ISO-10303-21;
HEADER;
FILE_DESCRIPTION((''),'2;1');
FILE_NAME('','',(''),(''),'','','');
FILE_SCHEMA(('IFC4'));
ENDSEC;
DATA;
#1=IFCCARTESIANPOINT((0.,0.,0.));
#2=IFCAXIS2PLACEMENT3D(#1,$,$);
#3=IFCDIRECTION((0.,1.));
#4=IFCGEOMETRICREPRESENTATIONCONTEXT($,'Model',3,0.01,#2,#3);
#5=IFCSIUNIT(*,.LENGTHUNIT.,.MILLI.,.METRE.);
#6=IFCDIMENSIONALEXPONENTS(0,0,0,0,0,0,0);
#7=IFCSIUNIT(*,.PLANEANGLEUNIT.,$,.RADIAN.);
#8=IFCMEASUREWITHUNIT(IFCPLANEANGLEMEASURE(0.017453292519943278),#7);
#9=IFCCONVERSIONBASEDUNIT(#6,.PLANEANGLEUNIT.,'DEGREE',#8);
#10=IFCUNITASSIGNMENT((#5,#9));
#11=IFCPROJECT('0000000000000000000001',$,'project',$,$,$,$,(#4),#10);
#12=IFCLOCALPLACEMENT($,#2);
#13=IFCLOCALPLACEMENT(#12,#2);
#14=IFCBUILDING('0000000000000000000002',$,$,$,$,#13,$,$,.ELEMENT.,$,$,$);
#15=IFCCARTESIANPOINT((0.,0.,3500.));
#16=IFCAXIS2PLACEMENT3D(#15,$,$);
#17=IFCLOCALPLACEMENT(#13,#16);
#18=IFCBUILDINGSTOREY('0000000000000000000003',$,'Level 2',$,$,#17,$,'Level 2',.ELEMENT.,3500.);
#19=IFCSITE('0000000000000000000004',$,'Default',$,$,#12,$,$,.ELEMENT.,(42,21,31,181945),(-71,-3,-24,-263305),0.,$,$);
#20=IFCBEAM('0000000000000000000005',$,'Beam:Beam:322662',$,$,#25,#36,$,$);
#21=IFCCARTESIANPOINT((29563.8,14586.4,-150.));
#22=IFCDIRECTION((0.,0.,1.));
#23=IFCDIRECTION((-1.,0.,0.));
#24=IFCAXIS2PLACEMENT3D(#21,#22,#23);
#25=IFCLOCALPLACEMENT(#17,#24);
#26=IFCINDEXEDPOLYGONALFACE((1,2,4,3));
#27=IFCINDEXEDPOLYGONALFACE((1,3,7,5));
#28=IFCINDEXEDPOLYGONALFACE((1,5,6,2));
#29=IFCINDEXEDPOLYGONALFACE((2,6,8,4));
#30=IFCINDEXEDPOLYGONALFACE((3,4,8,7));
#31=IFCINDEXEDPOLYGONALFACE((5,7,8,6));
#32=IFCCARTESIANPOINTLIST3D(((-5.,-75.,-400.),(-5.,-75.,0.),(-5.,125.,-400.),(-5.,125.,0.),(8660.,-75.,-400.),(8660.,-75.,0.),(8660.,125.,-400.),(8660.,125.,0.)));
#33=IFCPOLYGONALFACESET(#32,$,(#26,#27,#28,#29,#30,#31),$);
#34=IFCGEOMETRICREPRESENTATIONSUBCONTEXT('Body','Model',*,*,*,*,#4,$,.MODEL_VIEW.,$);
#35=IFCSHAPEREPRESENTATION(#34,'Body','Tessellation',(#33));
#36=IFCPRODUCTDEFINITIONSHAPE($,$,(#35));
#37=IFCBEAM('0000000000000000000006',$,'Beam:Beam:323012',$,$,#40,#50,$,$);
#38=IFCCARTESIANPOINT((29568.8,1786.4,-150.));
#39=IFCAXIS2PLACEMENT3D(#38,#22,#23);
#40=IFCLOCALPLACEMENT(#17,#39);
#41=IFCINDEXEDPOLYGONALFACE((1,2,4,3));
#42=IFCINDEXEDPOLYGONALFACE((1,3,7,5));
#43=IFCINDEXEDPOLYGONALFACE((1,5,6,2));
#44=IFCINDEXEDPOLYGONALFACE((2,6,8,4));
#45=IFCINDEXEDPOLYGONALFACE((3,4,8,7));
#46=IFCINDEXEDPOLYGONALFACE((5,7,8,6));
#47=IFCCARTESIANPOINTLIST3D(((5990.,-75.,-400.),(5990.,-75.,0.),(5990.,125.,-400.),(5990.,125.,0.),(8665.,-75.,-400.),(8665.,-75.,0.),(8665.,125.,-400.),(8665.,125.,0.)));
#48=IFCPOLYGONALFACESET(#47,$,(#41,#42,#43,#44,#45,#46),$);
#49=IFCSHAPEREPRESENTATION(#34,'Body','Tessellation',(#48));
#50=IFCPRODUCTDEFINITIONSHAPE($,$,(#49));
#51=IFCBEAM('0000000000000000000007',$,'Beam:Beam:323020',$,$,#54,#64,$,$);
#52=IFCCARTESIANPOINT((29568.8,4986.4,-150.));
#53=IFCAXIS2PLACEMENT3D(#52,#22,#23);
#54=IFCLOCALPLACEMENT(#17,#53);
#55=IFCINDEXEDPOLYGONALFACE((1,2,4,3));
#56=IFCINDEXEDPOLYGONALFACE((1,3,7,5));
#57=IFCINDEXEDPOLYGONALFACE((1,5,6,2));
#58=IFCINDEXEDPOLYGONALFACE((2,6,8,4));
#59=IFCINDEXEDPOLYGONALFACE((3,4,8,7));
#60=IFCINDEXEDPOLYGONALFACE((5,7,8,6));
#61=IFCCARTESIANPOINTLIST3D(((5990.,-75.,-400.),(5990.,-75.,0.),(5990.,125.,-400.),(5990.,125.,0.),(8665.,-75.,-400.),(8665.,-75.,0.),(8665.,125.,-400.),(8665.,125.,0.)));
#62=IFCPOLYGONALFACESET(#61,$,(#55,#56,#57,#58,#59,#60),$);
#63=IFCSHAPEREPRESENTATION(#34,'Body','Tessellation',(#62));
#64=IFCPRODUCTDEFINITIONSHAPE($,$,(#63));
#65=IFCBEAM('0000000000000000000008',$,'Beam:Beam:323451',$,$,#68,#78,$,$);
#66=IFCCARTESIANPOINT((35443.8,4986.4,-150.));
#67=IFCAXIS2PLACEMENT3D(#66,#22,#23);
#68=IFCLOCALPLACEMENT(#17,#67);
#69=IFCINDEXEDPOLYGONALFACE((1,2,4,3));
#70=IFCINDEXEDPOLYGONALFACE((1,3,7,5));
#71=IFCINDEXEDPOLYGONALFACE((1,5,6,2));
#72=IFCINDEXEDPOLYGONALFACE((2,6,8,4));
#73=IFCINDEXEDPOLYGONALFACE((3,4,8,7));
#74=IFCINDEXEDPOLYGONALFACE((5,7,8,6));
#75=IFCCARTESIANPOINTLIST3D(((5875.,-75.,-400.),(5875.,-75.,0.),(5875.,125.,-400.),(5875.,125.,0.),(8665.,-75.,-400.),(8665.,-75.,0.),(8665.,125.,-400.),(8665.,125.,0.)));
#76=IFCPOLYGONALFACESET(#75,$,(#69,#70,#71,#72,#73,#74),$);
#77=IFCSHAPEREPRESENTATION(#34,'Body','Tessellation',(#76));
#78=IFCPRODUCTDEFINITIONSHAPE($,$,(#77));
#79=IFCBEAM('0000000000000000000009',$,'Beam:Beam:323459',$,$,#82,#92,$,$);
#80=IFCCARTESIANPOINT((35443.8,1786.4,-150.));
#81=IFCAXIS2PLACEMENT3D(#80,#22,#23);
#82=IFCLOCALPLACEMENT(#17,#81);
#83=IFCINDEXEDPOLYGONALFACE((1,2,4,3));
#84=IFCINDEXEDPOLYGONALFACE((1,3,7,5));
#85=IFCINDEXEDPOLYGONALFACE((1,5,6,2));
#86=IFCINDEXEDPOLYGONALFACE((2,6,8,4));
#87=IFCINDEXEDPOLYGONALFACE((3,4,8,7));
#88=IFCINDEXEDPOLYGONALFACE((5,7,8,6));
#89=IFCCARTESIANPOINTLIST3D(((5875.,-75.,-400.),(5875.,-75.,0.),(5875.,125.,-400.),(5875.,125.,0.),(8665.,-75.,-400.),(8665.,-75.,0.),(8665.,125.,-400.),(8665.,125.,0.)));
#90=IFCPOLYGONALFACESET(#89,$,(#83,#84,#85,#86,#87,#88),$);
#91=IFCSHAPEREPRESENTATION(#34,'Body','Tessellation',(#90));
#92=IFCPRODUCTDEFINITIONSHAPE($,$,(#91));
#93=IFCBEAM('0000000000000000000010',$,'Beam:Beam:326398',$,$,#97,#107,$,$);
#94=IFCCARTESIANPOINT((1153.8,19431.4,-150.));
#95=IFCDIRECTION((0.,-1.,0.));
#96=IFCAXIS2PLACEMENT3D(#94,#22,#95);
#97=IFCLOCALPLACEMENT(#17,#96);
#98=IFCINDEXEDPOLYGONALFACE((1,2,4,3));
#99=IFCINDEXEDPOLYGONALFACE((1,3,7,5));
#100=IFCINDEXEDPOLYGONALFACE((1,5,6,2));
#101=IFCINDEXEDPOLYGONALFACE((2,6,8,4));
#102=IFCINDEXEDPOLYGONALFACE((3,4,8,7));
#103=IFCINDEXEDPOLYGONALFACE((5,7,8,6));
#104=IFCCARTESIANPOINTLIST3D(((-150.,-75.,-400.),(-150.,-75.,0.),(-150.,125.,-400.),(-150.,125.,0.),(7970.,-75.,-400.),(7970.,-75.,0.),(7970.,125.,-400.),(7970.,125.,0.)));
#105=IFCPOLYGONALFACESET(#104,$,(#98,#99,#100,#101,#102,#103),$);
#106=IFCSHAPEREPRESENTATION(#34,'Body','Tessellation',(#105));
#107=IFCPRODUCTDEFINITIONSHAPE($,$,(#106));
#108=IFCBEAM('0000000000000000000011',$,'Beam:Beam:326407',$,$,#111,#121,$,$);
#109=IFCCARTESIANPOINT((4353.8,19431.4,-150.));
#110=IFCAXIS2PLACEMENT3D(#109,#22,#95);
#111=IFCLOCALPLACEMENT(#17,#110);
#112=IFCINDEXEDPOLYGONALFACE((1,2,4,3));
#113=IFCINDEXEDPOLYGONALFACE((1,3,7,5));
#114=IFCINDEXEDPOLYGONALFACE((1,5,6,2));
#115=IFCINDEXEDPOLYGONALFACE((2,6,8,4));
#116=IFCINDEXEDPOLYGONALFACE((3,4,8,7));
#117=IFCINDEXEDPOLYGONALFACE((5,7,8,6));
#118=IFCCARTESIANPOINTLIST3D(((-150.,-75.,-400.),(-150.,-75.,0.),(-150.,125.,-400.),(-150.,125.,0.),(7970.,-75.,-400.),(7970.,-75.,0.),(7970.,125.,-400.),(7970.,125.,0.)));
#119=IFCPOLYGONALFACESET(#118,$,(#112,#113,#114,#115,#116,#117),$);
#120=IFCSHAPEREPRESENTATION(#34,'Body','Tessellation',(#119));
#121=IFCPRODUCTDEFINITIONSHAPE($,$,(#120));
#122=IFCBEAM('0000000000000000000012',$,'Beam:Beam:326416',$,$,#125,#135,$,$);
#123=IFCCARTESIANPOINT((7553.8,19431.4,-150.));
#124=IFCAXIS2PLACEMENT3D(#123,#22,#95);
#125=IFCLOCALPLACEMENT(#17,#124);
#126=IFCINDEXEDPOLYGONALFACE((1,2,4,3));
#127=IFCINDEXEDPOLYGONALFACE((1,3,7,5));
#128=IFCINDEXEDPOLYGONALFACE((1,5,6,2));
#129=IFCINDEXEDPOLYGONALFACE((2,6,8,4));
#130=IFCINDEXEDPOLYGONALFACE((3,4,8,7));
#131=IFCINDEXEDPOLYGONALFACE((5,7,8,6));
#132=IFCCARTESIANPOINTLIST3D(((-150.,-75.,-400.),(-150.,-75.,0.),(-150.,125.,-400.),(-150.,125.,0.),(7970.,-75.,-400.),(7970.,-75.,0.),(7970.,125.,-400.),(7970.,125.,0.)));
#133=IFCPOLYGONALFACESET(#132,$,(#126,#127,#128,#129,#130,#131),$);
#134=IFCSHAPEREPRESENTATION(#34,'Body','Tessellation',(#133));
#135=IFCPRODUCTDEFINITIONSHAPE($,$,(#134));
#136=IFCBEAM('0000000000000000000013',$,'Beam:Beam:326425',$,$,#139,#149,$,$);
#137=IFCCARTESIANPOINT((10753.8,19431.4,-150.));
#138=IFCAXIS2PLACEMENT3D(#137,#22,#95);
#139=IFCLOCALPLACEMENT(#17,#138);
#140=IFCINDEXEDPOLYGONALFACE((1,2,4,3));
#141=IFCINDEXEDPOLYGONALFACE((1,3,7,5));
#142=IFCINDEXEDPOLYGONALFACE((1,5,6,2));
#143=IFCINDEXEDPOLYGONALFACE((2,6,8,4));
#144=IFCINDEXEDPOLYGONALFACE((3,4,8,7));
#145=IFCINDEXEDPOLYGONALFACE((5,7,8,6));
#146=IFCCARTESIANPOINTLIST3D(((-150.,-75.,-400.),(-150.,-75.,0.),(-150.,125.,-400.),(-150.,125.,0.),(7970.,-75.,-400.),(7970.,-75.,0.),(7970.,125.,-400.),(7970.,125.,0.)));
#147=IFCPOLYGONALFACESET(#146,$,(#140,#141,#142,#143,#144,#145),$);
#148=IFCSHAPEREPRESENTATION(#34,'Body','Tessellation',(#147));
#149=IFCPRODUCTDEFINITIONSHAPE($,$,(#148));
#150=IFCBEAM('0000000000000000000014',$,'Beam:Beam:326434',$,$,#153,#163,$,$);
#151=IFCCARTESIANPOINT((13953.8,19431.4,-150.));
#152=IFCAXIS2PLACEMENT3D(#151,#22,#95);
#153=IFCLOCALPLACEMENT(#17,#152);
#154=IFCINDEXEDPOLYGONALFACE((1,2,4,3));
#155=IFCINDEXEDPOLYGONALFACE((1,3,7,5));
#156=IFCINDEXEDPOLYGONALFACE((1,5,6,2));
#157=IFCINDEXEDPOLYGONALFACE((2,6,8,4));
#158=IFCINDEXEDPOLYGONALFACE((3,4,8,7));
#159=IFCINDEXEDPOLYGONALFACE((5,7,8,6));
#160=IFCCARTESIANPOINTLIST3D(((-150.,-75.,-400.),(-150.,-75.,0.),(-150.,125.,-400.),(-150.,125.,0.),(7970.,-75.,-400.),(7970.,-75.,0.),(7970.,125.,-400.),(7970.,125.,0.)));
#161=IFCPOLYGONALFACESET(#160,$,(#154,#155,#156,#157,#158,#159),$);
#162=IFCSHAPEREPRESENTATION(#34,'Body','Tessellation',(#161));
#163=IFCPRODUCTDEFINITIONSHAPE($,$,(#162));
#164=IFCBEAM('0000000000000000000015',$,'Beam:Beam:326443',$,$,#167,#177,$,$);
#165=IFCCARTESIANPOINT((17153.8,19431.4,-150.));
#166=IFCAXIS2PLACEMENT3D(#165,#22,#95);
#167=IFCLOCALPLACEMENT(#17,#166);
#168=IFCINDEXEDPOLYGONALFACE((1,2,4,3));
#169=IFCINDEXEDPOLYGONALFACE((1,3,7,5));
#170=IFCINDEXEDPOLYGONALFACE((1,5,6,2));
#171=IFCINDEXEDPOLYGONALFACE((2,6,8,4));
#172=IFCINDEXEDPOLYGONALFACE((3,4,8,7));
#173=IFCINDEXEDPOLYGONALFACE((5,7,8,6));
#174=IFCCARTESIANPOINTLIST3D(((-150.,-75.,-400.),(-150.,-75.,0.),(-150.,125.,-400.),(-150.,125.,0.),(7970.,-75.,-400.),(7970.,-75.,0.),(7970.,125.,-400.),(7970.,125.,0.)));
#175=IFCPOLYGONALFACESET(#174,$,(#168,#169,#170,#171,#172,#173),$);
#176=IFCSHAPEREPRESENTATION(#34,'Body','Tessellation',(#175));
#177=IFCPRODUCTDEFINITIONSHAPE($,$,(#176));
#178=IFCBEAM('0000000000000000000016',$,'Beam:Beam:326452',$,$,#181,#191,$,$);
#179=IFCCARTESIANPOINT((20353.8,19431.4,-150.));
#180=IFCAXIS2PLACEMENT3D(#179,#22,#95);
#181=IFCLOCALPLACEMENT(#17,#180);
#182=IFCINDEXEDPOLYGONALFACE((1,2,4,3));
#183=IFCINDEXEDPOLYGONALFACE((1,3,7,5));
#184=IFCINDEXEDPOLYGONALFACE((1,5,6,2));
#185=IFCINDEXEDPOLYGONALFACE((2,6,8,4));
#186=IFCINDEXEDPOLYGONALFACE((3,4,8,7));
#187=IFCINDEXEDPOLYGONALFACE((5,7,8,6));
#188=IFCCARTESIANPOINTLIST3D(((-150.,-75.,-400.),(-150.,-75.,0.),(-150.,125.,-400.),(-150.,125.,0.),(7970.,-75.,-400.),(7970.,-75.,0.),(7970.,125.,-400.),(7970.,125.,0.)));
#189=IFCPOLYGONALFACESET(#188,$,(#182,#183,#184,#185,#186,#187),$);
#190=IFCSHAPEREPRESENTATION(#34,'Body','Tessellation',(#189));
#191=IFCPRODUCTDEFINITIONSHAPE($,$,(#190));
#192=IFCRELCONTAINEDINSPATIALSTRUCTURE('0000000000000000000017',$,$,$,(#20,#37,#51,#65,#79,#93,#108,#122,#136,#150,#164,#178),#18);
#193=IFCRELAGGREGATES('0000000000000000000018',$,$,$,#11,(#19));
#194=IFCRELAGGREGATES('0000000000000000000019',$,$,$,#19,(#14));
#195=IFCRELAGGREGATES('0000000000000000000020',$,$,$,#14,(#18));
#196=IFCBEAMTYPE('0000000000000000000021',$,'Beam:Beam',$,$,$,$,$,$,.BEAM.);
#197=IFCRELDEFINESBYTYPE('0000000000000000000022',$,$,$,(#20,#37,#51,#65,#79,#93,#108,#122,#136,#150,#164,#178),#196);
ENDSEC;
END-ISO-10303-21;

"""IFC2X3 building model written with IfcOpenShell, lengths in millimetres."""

from ifc_helpers import new_model, entity, si_unit, converted_unit, direction, frame, frame_2d, origin, origin_2d_with_axis, place, context, subcontext, project, spatial, rectangle, extrude, type_object, element, save


model = new_model("IFC2X3")

# Units and contexts
model_context = context("Model", 3, precision=0.01, world=origin(), true_north=direction((0.0, 1.0)))
body_context = subcontext(model_context, "Body", "Model", "MODEL_VIEW")
ifc_project = project(units=[si_unit("LENGTHUNIT", "METRE", prefix="MILLI"), converted_unit("PLANEANGLEUNIT", "DEGREE", entity("IfcPlaneAngleMeasure", 0.017453292519943278), si_unit("PLANEANGLEUNIT", "RADIAN"), dimensions=[0, 0, 0, 0, 0, 0, 0])], contexts=[model_context])

# Site, building, storey
site_placement = place(None, origin())
site = spatial("IfcSite", under=ifc_project, at=site_placement, Name="Default", CompositionType="ELEMENT", RefLatitude=(42, 21, 31, 181945), RefLongitude=(-71, -3, -24, -263305), RefElevation=0.0)
building_placement = place(site_placement, origin())
building = spatial("IfcBuilding", under=site, at=building_placement, CompositionType="ELEMENT")
storey_placement = place(building_placement, frame((0.0, 0.0, 3500.0)))
storey = spatial("IfcBuildingStorey", under=building, at=storey_placement, Name="Level 2", LongName="Level 2", CompositionType="ELEMENT", Elevation=3500.0)

# Beams
beam_type = type_object("IfcBeamType", Name="Beam:Beam", PredefinedType="BEAM")
beam_1_placement = place(storey_placement, frame((29563.8, 14586.4, -150.0), z_axis=(0.0, 0.0, 1.0), x_axis=(-1.0, 0.0, 0.0)))
element("IfcBeam", 1, at=beam_1_placement, inside=storey, type_object=beam_type, Name="Beam:Beam:322662", context=body_context, shape_type="SweptSolid", body=[
    extrude(rectangle(XDim=400.0, YDim=200.0, at=frame_2d((0.0, 0.0), x_axis=(1.0, 0.0))), frame((-5.0, 25.0, -200.0), z_axis=(1.0, 0.0, 0.0), x_axis=(0.0, 0.0, -1.0)), (0.0, 0.0, 1.0), 8665.0),
])
beam_2_placement = place(storey_placement, frame((29568.8, 1786.4, -150.0), z_axis=(0.0, 0.0, 1.0), x_axis=(-1.0, 0.0, 0.0)))
element("IfcBeam", 2, at=beam_2_placement, inside=storey, type_object=beam_type, Name="Beam:Beam:323012", context=body_context, shape_type="SweptSolid", body=[
    extrude(rectangle(XDim=400.0, YDim=200.0, at=frame_2d((0.0, 0.0), x_axis=(1.0, 0.0))), frame((5990.0, 25.0, -200.0), z_axis=(1.0, 0.0, 0.0), x_axis=(0.0, 0.0, -1.0)), (0.0, 0.0, 1.0), 2675.0),
])
beam_3_placement = place(storey_placement, frame((29568.8, 4986.4, -150.0), z_axis=(0.0, 0.0, 1.0), x_axis=(-1.0, 0.0, 0.0)))
element("IfcBeam", 3, at=beam_3_placement, inside=storey, type_object=beam_type, Name="Beam:Beam:323020", context=body_context, shape_type="SweptSolid", body=[
    extrude(rectangle(XDim=400.0, YDim=200.0, at=frame_2d((0.0, 0.0), x_axis=(1.0, 0.0))), frame((5990.0, 25.0, -200.0), z_axis=(1.0, 0.0, 0.0), x_axis=(0.0, 0.0, -1.0)), (0.0, 0.0, 1.0), 2675.0),
])
beam_4_placement = place(storey_placement, frame((35443.8, 4986.4, -150.0), z_axis=(0.0, 0.0, 1.0), x_axis=(-1.0, 0.0, 0.0)))
element("IfcBeam", 4, at=beam_4_placement, inside=storey, type_object=beam_type, Name="Beam:Beam:323451", context=body_context, shape_type="SweptSolid", body=[
    extrude(rectangle(XDim=400.0, YDim=200.0, at=origin_2d_with_axis()), frame((5875.0, 25.0, -200.0), z_axis=(1.0, 0.0, 0.0), x_axis=(0.0, 0.0, -1.0)), (0.0, 0.0, 1.0), 2790.0),
])
beam_5_placement = place(storey_placement, frame((35443.8, 1786.4, -150.0), z_axis=(0.0, 0.0, 1.0), x_axis=(-1.0, 0.0, 0.0)))
element("IfcBeam", 5, at=beam_5_placement, inside=storey, type_object=beam_type, Name="Beam:Beam:323459", context=body_context, shape_type="SweptSolid", body=[
    extrude(rectangle(XDim=400.0, YDim=200.0, at=frame_2d((0.0, 0.0), x_axis=(1.0, 0.0))), frame((5875.0, 25.0, -200.0), z_axis=(1.0, 0.0, 0.0), x_axis=(0.0, 0.0, -1.0)), (0.0, 0.0, 1.0), 2790.0),
])
beam_6_placement = place(storey_placement, frame((1153.8, 19431.4, -150.0), z_axis=(0.0, 0.0, 1.0), x_axis=(0.0, -1.0, 0.0)))
element("IfcBeam", 6, at=beam_6_placement, inside=storey, type_object=beam_type, Name="Beam:Beam:326398", context=body_context, shape_type="SweptSolid", body=[
    extrude(rectangle(XDim=400.0, YDim=200.0, at=frame_2d((0.0, 0.0), x_axis=(1.0, 0.0))), frame((-150.0, 25.0, -200.0), z_axis=(1.0, 0.0, 0.0), x_axis=(0.0, 0.0, -1.0)), (0.0, 0.0, 1.0), 8120.0),
])
beam_7_placement = place(storey_placement, frame((4353.8, 19431.4, -150.0), z_axis=(0.0, 0.0, 1.0), x_axis=(0.0, -1.0, 0.0)))
element("IfcBeam", 7, at=beam_7_placement, inside=storey, type_object=beam_type, Name="Beam:Beam:326407", context=body_context, shape_type="SweptSolid", body=[
    extrude(rectangle(XDim=400.0, YDim=200.0, at=frame_2d((0.0, 0.0), x_axis=(1.0, 0.0))), frame((-150.0, 25.0, -200.0), z_axis=(1.0, 0.0, 0.0), x_axis=(0.0, 0.0, -1.0)), (0.0, 0.0, 1.0), 8120.0),
])
beam_8_placement = place(storey_placement, frame((7553.8, 19431.4, -150.0), z_axis=(0.0, 0.0, 1.0), x_axis=(0.0, -1.0, 0.0)))
element("IfcBeam", 8, at=beam_8_placement, inside=storey, type_object=beam_type, Name="Beam:Beam:326416", context=body_context, shape_type="SweptSolid", body=[
    extrude(rectangle(XDim=400.0, YDim=200.0, at=frame_2d((0.0, 0.0), x_axis=(1.0, 0.0))), frame((-150.0, 25.0, -200.0), z_axis=(1.0, 0.0, 0.0), x_axis=(0.0, 0.0, -1.0)), (0.0, 0.0, 1.0), 8120.0),
])
beam_9_placement = place(storey_placement, frame((10753.8, 19431.4, -150.0), z_axis=(0.0, 0.0, 1.0), x_axis=(0.0, -1.0, 0.0)))
element("IfcBeam", 9, at=beam_9_placement, inside=storey, type_object=beam_type, Name="Beam:Beam:326425", context=body_context, shape_type="SweptSolid", body=[
    extrude(rectangle(XDim=400.0, YDim=200.0, at=frame_2d((0.0, 0.0), x_axis=(1.0, 0.0))), frame((-150.0, 25.0, -200.0), z_axis=(1.0, 0.0, 0.0), x_axis=(0.0, 0.0, -1.0)), (0.0, 0.0, 1.0), 8120.0),
])
for number, where, z_axis, x_axis, name in (
    (10, (13953.8, 19431.4, -150.0), (0.0, 0.0, 1.0), (0.0, -1.0, 0.0), "Beam:Beam:326434"),
    (11, (17153.8, 19431.4, -150.0), (0.0, 0.0, 1.0), (0.0, -1.0, 0.0), "Beam:Beam:326443"),
):
    element("IfcBeam", number, at=place(storey_placement, frame(where, z_axis=z_axis, x_axis=x_axis)), inside=storey, type_object=beam_type, Name=name, context=body_context, shape_type="SweptSolid", body=[
        extrude(rectangle(XDim=400.0, YDim=200.0, at=frame_2d((0.0, 0.0), x_axis=(1.0, 0.0))), frame((-150.0, 25.0, -200.0), z_axis=(1.0, 0.0, 0.0), x_axis=(0.0, 0.0, -1.0)), (0.0, 0.0, 1.0), 8120.0),
    ])
beam_10_placement = place(storey_placement, frame((20353.8, 19431.4, -150.0), z_axis=(0.0, 0.0, 1.0), x_axis=(0.0, -1.0, 0.0)))
element("IfcBeam", 12, at=beam_10_placement, inside=storey, type_object=beam_type, Name="Beam:Beam:326452", context=body_context, shape_type="SweptSolid", body=[
    extrude(rectangle(XDim=400.0, YDim=200.0, at=frame_2d((0.0, 0.0), x_axis=(1.0, 0.0))), frame((-150.0, 25.0, -200.0), z_axis=(1.0, 0.0, 0.0), x_axis=(0.0, 0.0, -1.0)), (0.0, 0.0, 1.0), 8120.0),
])

save(model, "model.ifc")
